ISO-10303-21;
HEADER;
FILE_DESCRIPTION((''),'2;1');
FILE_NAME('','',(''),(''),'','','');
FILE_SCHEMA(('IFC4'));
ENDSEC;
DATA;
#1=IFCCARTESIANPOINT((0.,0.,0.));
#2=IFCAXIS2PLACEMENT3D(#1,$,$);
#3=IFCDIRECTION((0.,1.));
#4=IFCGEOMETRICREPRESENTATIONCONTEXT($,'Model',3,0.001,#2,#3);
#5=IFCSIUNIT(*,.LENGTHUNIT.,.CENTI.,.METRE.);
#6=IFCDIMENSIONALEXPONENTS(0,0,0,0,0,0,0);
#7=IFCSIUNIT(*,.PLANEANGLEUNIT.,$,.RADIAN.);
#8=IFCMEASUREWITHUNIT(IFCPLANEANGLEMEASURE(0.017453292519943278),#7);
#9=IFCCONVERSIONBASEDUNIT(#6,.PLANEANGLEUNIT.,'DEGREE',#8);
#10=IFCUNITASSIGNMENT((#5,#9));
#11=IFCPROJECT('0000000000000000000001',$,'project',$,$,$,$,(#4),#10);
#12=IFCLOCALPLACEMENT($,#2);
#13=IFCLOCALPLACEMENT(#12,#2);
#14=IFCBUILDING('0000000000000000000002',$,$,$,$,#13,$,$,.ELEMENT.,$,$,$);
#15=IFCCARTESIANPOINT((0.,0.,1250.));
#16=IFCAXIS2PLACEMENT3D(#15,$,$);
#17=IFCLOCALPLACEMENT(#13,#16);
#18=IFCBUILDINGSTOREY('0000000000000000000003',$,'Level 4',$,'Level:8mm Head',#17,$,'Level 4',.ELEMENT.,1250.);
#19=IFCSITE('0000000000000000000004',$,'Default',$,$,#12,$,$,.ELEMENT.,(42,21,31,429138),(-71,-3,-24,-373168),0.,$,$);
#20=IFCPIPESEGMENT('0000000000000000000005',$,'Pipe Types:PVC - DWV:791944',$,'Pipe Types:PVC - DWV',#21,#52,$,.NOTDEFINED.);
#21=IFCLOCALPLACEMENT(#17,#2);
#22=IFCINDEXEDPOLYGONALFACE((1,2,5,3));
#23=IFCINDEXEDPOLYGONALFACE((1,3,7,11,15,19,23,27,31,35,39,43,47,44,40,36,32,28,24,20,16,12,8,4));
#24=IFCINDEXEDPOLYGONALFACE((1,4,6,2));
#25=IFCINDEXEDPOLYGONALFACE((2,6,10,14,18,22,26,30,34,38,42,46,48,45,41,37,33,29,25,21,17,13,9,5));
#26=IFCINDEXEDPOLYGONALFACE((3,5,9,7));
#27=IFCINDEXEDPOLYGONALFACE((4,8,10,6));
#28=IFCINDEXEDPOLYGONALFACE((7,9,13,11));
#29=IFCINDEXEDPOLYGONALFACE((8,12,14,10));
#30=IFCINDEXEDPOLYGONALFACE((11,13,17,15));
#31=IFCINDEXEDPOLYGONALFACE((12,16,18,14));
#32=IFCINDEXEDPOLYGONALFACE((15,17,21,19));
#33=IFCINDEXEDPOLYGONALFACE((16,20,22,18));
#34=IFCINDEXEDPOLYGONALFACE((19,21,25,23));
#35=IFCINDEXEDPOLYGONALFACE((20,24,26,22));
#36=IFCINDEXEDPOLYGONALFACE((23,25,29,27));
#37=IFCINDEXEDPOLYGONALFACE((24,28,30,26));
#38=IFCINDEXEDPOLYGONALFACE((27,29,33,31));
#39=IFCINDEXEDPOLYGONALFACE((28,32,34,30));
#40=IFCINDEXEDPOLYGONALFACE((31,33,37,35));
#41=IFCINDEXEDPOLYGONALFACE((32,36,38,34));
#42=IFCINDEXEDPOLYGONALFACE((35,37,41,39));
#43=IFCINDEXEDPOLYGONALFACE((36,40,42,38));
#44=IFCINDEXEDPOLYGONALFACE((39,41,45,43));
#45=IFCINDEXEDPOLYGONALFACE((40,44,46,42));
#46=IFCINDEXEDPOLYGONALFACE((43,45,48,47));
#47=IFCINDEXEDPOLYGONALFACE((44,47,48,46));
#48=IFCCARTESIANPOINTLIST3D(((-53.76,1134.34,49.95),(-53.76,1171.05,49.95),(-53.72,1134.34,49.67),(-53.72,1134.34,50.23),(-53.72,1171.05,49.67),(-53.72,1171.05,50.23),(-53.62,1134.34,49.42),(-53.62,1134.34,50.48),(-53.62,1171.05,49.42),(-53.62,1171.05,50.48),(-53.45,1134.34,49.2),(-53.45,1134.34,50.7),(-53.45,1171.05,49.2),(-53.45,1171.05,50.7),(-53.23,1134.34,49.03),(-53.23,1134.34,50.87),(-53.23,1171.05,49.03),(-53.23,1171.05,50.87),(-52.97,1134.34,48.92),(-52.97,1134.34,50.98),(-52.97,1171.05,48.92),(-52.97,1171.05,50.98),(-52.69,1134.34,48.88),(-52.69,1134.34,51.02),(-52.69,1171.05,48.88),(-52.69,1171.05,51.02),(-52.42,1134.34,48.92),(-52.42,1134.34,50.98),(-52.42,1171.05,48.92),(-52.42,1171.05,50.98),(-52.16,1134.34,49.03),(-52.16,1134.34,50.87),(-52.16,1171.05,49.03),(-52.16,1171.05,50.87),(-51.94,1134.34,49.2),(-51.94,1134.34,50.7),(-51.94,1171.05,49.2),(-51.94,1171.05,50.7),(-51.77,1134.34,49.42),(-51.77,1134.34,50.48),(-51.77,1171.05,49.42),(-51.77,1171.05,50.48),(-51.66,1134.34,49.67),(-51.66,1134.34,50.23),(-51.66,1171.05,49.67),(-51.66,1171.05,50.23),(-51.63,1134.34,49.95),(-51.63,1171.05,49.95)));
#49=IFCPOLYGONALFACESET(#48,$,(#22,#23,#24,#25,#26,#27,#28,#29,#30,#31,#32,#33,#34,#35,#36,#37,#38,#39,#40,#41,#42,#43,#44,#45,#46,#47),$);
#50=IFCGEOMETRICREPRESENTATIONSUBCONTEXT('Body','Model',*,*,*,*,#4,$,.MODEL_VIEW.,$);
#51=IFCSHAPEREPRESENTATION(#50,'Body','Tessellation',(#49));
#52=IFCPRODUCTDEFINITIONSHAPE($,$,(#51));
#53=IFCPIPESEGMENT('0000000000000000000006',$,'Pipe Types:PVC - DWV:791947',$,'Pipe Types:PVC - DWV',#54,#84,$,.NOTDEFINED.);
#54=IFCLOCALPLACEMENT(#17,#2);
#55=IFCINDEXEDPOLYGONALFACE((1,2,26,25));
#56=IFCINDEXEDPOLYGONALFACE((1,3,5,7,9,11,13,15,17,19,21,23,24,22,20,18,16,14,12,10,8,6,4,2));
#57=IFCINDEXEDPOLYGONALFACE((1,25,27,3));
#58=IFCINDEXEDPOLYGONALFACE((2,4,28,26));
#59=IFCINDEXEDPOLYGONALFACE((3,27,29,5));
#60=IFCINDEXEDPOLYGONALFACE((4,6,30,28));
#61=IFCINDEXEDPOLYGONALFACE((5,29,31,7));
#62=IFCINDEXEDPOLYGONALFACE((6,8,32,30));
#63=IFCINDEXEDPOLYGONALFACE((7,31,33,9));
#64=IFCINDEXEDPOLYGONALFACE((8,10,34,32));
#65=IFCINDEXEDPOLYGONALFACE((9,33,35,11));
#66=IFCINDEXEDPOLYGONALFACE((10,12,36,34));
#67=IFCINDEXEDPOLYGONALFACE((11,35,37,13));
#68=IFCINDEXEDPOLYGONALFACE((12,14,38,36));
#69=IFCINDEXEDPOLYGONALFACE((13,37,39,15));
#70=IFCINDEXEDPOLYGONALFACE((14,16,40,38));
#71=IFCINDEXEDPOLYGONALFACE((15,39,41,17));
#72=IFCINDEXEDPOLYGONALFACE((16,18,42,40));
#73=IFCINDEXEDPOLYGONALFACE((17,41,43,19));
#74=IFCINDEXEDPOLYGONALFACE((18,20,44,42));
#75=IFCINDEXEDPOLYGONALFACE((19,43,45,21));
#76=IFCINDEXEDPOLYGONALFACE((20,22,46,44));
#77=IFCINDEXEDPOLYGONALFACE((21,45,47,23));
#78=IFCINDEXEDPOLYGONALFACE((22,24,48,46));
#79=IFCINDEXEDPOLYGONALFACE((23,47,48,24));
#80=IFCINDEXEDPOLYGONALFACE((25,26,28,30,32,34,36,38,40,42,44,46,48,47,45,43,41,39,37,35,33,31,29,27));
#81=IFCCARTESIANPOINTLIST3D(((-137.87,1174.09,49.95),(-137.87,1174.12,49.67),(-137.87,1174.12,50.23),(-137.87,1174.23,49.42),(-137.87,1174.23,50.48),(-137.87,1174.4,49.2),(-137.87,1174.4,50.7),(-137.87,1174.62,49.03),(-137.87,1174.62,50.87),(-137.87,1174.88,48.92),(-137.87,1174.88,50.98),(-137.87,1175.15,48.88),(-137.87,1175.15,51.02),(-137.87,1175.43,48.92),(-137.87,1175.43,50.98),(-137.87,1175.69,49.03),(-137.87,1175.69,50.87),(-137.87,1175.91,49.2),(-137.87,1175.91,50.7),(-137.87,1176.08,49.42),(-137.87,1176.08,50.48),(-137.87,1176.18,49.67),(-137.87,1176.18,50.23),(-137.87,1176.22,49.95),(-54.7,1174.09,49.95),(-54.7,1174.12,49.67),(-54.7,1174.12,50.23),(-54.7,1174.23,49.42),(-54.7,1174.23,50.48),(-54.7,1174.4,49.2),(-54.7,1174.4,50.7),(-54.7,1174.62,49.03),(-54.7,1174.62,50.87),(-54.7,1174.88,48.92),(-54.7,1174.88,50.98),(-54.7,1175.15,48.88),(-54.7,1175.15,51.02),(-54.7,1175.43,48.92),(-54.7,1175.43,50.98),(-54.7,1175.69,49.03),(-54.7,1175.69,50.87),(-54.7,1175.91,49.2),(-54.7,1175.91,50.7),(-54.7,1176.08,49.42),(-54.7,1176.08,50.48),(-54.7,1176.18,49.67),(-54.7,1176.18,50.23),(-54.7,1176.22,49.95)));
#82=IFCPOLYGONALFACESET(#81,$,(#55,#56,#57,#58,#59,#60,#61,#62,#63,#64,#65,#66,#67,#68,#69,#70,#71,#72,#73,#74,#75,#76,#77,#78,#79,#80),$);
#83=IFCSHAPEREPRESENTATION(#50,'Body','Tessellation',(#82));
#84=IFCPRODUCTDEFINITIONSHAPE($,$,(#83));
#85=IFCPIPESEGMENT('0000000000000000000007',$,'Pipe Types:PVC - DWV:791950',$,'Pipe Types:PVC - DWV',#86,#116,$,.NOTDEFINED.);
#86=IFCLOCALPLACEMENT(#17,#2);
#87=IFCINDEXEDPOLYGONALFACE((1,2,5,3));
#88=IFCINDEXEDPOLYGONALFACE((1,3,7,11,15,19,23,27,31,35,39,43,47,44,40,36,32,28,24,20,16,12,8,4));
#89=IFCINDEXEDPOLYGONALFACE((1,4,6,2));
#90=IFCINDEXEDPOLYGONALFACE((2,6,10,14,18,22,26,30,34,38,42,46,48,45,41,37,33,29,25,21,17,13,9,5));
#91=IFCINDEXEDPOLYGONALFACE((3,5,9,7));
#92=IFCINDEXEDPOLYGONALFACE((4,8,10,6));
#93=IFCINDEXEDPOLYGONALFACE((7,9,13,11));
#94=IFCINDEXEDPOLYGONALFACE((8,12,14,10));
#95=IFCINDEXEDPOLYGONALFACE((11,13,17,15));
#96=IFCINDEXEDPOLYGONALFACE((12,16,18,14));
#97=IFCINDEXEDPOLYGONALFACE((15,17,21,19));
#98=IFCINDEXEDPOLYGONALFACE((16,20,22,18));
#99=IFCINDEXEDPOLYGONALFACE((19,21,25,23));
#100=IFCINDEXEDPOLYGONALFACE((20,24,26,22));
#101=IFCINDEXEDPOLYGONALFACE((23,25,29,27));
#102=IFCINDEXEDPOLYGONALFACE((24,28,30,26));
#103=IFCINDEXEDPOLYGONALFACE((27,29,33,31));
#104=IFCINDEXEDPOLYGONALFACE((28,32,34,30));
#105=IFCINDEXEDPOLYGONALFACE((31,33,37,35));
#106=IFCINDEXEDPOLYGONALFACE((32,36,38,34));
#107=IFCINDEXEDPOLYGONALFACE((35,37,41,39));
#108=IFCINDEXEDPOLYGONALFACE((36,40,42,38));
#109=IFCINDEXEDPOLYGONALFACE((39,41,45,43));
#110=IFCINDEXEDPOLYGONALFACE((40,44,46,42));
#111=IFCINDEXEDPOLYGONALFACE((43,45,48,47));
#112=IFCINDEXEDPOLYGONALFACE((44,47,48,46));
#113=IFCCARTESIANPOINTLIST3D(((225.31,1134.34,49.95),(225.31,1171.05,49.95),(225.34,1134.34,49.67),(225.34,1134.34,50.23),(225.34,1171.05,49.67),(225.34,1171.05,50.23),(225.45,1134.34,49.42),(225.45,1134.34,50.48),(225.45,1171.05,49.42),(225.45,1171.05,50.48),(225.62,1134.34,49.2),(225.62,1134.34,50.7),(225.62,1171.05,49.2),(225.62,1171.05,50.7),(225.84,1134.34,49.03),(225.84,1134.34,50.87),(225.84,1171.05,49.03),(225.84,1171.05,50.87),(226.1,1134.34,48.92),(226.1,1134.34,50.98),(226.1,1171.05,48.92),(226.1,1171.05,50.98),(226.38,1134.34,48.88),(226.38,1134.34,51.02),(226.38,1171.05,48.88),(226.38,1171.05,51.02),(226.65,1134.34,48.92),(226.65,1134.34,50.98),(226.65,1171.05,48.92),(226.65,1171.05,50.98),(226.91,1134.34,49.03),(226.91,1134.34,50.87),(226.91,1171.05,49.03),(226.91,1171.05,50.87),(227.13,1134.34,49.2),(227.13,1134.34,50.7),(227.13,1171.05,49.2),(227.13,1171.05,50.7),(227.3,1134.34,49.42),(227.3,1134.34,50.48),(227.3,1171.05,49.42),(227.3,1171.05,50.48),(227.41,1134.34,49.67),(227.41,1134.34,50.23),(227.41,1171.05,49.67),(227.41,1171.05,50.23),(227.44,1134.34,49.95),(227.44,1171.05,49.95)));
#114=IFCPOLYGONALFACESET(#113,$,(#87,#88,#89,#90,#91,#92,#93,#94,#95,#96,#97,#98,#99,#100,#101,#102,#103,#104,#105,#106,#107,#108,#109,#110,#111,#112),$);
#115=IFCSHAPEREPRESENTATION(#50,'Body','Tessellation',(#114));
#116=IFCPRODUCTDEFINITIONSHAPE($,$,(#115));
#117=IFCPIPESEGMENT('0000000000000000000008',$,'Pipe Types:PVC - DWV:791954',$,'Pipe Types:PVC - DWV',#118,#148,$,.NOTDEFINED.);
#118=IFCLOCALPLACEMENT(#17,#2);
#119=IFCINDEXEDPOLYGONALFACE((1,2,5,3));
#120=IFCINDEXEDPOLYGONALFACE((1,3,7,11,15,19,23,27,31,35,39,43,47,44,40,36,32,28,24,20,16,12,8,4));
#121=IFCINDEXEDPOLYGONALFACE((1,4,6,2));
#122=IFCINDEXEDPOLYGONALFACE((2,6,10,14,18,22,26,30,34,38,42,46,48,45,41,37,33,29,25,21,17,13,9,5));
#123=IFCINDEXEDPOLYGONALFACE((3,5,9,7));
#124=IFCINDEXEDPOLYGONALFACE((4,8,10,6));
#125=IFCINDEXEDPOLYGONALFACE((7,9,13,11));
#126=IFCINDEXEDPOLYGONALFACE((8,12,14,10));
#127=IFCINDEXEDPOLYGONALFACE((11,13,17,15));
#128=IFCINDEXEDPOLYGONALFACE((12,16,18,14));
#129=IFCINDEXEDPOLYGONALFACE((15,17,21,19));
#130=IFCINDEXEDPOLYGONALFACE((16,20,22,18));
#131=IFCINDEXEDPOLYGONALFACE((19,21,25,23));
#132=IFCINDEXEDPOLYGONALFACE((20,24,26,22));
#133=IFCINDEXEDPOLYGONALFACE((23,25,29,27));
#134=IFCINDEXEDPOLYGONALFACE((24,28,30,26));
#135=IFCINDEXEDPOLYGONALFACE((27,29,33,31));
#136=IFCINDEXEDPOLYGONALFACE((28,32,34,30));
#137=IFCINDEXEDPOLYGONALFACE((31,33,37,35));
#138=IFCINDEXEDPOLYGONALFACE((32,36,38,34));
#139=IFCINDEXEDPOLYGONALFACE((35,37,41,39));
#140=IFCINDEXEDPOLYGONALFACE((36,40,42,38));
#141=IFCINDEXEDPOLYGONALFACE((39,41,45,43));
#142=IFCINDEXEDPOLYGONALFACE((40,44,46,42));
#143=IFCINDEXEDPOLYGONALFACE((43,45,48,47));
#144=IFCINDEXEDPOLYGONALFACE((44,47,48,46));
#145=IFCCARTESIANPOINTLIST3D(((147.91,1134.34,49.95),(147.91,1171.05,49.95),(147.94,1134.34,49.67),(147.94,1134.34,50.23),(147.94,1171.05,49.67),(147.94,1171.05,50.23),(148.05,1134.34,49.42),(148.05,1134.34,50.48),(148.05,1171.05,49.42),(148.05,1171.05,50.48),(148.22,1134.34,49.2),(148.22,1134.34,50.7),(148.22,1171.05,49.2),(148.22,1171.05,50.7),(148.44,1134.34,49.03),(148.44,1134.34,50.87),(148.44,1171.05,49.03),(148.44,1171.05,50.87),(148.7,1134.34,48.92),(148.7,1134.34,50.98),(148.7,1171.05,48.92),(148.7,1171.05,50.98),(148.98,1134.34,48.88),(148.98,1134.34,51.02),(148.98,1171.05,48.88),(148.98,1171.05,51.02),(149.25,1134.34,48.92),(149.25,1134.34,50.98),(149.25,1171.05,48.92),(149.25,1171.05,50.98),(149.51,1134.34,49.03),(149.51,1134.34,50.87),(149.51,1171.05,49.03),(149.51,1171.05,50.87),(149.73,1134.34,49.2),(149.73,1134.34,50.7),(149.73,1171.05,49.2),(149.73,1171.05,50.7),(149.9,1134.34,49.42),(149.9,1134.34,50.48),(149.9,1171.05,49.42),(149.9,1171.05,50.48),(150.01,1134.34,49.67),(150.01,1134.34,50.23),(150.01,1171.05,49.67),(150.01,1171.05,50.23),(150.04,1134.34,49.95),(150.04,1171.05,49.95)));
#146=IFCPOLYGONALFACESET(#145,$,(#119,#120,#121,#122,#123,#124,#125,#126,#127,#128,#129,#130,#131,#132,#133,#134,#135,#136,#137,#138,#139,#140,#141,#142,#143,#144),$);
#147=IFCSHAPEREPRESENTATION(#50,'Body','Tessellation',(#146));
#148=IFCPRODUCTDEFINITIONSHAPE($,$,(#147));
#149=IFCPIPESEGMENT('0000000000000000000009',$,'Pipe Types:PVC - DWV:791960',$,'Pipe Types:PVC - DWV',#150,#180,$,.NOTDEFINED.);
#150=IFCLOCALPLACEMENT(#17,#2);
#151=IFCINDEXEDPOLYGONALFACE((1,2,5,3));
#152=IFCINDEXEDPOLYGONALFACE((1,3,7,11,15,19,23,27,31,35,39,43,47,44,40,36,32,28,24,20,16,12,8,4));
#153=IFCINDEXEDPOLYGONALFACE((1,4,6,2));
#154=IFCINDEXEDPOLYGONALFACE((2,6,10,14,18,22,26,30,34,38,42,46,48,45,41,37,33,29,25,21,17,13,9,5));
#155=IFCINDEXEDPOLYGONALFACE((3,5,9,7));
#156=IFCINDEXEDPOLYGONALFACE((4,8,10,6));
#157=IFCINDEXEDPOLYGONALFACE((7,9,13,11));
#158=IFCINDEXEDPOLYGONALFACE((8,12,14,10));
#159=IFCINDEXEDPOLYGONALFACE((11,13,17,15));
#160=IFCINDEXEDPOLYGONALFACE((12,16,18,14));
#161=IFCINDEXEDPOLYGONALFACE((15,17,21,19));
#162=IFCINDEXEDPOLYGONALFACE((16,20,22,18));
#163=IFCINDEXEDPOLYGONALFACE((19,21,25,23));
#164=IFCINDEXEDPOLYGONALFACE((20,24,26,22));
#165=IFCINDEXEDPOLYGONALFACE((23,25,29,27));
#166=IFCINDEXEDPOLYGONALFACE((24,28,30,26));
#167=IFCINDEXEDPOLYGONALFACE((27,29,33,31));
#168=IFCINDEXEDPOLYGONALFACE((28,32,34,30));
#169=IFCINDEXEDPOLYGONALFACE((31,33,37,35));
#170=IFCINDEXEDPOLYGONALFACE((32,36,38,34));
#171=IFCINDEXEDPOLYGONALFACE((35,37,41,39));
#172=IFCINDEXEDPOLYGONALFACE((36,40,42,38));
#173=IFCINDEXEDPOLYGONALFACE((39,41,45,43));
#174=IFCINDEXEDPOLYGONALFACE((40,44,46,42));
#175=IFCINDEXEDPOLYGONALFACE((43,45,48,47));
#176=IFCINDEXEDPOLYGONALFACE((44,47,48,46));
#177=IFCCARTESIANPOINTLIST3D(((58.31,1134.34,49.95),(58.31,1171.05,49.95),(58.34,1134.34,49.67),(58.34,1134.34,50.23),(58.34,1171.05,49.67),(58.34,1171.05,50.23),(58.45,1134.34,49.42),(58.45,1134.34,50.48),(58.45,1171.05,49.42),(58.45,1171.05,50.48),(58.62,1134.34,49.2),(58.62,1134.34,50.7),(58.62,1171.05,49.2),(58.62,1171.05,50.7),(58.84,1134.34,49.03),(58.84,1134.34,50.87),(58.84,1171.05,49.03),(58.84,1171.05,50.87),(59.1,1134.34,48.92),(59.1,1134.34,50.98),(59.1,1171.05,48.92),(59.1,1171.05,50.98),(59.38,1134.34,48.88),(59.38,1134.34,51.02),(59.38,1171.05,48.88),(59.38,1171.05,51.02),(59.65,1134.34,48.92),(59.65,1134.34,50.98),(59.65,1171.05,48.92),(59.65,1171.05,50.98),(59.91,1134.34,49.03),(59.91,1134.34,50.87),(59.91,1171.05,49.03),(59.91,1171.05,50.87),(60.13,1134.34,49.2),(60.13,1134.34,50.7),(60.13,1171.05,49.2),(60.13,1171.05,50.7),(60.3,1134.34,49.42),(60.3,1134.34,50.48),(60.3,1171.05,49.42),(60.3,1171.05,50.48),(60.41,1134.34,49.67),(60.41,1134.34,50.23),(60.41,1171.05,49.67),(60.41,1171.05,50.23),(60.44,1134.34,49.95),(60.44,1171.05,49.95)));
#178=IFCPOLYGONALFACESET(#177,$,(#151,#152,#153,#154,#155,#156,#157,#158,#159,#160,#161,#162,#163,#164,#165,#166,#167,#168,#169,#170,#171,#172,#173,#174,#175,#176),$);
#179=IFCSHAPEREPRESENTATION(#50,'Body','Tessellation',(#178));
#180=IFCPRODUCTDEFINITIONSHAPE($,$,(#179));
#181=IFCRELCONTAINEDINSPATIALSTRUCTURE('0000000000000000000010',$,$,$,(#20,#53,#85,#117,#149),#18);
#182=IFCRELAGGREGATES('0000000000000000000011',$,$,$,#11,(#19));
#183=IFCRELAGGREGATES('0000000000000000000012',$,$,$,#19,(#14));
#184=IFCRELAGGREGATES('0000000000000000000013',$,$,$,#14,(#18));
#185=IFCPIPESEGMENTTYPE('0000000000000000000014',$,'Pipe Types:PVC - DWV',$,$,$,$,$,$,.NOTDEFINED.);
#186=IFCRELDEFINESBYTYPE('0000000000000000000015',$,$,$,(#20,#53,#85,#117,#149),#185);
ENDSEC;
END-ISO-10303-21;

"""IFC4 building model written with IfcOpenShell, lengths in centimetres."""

from ifc_helpers import new_model, entity, si_unit, converted_unit, direction, frame, origin, place, context, subcontext, project, spatial, arc, indexed_curve, outline, extrude, type_object, element, save


model = new_model("IFC4")

# Units and contexts
model_context = context("Model", 3, precision=0.001, world=origin(), true_north=direction((0.0, 1.0)))
body_context = subcontext(model_context, "Body", "Model", "MODEL_VIEW")
ifc_project = project(units=[si_unit("LENGTHUNIT", "METRE", prefix="CENTI"), converted_unit("PLANEANGLEUNIT", "DEGREE", entity("IfcPlaneAngleMeasure", 0.017453292519943278), si_unit("PLANEANGLEUNIT", "RADIAN"), dimensions=[0, 0, 0, 0, 0, 0, 0])], contexts=[model_context])

# Site, building, storey
site_placement = place(None, origin())
site = spatial("IfcSite", under=ifc_project, at=site_placement, Name="Default", CompositionType="ELEMENT", RefLatitude=(42, 21, 31, 429138), RefLongitude=(-71, -3, -24, -373168), RefElevation=0.0)
building_placement = place(site_placement, origin())
building = spatial("IfcBuilding", under=site, at=building_placement, CompositionType="ELEMENT")
storey_placement = place(building_placement, frame((0.0, 0.0, 1250.0)))
storey = spatial("IfcBuildingStorey", under=building, at=storey_placement, Name="Level 4", ObjectType="Level:8mm Head", LongName="Level 4", CompositionType="ELEMENT", Elevation=1250.0)

# Pipe segments
pipe_segment_type = type_object("IfcPipeSegmentType", Name="Pipe Types:PVC - DWV", PredefinedType="NOTDEFINED")
pipe_segment_1_placement = place(storey_placement, origin())
element("IfcPipeSegment", 1, at=pipe_segment_1_placement, inside=storey, type_object=pipe_segment_type, Name="Pipe Types:PVC - DWV:791944", ObjectType="Pipe Types:PVC - DWV", PredefinedType="NOTDEFINED", context=body_context, shape_type="SweptSolid", body=[
    extrude(outline(indexed_curve([(1.07, 0.0), (0.75, 0.75), (0.0, 1.07), (-0.75, 0.75), (-1.07, 0.0), (-0.75, -0.75), (0.0, -1.07), (0.75, -0.75)], segments=[arc(1, 2, 3), arc(3, 4, 5), arc(5, 6, 7), arc(7, 8, 1)], self_intersect=False)), frame((-52.69, 1134.34, 49.95), z_axis=(0.0, 1.0, 0.0), x_axis=(-1.0, 0.0, 0.0)), (0.0, 0.0, 1.0), 36.71),
])
pipe_segment_2_placement = place(storey_placement, origin())
element("IfcPipeSegment", 2, at=pipe_segment_2_placement, inside=storey, type_object=pipe_segment_type, Name="Pipe Types:PVC - DWV:791947", ObjectType="Pipe Types:PVC - DWV", PredefinedType="NOTDEFINED", context=body_context, shape_type="SweptSolid", body=[
    extrude(outline(indexed_curve([(1.07, 0.0), (0.75, 0.75), (0.0, 1.07), (-0.75, 0.75), (-1.07, 0.0), (-0.75, -0.75), (0.0, -1.07), (0.75, -0.75)], segments=[arc(1, 2, 3), arc(3, 4, 5), arc(5, 6, 7), arc(7, 8, 1)], self_intersect=False)), frame((-137.87, 1175.15, 49.95), z_axis=(1.0, 0.0, 0.0), x_axis=(0.0, -1.0, 0.0)), (0.0, 0.0, 1.0), 83.17),
])
pipe_segment_3_placement = place(storey_placement, origin())
element("IfcPipeSegment", 3, at=pipe_segment_3_placement, inside=storey, type_object=pipe_segment_type, Name="Pipe Types:PVC - DWV:791950", ObjectType="Pipe Types:PVC - DWV", PredefinedType="NOTDEFINED", context=body_context, shape_type="SweptSolid", body=[
    extrude(outline(indexed_curve([(1.07, 0.0), (0.75, 0.75), (0.0, 1.07), (-0.75, 0.75), (-1.07, 0.0), (-0.75, -0.75), (0.0, -1.07), (0.75, -0.75)], segments=[arc(1, 2, 3), arc(3, 4, 5), arc(5, 6, 7), arc(7, 8, 1)], self_intersect=False)), frame((226.38, 1134.34, 49.95), z_axis=(0.0, 1.0, 0.0), x_axis=(-1.0, 0.0, 0.0)), (0.0, 0.0, 1.0), 36.71),
])
pipe_segment_4_placement = place(storey_placement, origin())
element("IfcPipeSegment", 4, at=pipe_segment_4_placement, inside=storey, type_object=pipe_segment_type, Name="Pipe Types:PVC - DWV:791954", ObjectType="Pipe Types:PVC - DWV", PredefinedType="NOTDEFINED", context=body_context, shape_type="SweptSolid", body=[
    extrude(outline(indexed_curve([(1.07, 0.0), (0.75, 0.75), (0.0, 1.07), (-0.75, 0.75), (-1.07, 0.0), (-0.75, -0.75), (0.0, -1.07), (0.75, -0.75)], segments=[arc(1, 2, 3), arc(3, 4, 5), arc(5, 6, 7), arc(7, 8, 1)], self_intersect=False)), frame((148.98, 1134.34, 49.95), z_axis=(0.0, 1.0, 0.0), x_axis=(-1.0, 0.0, 0.0)), (0.0, 0.0, 1.0), 36.71),
])
pipe_segment_5_placement = place(storey_placement, origin())
element("IfcPipeSegment", 5, at=pipe_segment_5_placement, inside=storey, type_object=pipe_segment_type, Name="Pipe Types:PVC - DWV:791960", ObjectType="Pipe Types:PVC - DWV", PredefinedType="NOTDEFINED", context=body_context, shape_type="SweptSolid", body=[
    extrude(outline(indexed_curve([(1.07, 0.0), (0.75, 0.75), (0.0, 1.07), (-0.75, 0.75), (-1.07, 0.0), (-0.75, -0.75), (0.0, -1.07), (0.75, -0.75)], segments=[arc(1, 2, 3), arc(3, 4, 5), arc(5, 6, 7), arc(7, 8, 1)], self_intersect=False)), frame((59.38, 1134.34, 49.95), z_axis=(0.0, 1.0, 0.0), x_axis=(-1.0, 0.0, 0.0)), (0.0, 0.0, 1.0), 36.71),
])

save(model, "model.ifc")
